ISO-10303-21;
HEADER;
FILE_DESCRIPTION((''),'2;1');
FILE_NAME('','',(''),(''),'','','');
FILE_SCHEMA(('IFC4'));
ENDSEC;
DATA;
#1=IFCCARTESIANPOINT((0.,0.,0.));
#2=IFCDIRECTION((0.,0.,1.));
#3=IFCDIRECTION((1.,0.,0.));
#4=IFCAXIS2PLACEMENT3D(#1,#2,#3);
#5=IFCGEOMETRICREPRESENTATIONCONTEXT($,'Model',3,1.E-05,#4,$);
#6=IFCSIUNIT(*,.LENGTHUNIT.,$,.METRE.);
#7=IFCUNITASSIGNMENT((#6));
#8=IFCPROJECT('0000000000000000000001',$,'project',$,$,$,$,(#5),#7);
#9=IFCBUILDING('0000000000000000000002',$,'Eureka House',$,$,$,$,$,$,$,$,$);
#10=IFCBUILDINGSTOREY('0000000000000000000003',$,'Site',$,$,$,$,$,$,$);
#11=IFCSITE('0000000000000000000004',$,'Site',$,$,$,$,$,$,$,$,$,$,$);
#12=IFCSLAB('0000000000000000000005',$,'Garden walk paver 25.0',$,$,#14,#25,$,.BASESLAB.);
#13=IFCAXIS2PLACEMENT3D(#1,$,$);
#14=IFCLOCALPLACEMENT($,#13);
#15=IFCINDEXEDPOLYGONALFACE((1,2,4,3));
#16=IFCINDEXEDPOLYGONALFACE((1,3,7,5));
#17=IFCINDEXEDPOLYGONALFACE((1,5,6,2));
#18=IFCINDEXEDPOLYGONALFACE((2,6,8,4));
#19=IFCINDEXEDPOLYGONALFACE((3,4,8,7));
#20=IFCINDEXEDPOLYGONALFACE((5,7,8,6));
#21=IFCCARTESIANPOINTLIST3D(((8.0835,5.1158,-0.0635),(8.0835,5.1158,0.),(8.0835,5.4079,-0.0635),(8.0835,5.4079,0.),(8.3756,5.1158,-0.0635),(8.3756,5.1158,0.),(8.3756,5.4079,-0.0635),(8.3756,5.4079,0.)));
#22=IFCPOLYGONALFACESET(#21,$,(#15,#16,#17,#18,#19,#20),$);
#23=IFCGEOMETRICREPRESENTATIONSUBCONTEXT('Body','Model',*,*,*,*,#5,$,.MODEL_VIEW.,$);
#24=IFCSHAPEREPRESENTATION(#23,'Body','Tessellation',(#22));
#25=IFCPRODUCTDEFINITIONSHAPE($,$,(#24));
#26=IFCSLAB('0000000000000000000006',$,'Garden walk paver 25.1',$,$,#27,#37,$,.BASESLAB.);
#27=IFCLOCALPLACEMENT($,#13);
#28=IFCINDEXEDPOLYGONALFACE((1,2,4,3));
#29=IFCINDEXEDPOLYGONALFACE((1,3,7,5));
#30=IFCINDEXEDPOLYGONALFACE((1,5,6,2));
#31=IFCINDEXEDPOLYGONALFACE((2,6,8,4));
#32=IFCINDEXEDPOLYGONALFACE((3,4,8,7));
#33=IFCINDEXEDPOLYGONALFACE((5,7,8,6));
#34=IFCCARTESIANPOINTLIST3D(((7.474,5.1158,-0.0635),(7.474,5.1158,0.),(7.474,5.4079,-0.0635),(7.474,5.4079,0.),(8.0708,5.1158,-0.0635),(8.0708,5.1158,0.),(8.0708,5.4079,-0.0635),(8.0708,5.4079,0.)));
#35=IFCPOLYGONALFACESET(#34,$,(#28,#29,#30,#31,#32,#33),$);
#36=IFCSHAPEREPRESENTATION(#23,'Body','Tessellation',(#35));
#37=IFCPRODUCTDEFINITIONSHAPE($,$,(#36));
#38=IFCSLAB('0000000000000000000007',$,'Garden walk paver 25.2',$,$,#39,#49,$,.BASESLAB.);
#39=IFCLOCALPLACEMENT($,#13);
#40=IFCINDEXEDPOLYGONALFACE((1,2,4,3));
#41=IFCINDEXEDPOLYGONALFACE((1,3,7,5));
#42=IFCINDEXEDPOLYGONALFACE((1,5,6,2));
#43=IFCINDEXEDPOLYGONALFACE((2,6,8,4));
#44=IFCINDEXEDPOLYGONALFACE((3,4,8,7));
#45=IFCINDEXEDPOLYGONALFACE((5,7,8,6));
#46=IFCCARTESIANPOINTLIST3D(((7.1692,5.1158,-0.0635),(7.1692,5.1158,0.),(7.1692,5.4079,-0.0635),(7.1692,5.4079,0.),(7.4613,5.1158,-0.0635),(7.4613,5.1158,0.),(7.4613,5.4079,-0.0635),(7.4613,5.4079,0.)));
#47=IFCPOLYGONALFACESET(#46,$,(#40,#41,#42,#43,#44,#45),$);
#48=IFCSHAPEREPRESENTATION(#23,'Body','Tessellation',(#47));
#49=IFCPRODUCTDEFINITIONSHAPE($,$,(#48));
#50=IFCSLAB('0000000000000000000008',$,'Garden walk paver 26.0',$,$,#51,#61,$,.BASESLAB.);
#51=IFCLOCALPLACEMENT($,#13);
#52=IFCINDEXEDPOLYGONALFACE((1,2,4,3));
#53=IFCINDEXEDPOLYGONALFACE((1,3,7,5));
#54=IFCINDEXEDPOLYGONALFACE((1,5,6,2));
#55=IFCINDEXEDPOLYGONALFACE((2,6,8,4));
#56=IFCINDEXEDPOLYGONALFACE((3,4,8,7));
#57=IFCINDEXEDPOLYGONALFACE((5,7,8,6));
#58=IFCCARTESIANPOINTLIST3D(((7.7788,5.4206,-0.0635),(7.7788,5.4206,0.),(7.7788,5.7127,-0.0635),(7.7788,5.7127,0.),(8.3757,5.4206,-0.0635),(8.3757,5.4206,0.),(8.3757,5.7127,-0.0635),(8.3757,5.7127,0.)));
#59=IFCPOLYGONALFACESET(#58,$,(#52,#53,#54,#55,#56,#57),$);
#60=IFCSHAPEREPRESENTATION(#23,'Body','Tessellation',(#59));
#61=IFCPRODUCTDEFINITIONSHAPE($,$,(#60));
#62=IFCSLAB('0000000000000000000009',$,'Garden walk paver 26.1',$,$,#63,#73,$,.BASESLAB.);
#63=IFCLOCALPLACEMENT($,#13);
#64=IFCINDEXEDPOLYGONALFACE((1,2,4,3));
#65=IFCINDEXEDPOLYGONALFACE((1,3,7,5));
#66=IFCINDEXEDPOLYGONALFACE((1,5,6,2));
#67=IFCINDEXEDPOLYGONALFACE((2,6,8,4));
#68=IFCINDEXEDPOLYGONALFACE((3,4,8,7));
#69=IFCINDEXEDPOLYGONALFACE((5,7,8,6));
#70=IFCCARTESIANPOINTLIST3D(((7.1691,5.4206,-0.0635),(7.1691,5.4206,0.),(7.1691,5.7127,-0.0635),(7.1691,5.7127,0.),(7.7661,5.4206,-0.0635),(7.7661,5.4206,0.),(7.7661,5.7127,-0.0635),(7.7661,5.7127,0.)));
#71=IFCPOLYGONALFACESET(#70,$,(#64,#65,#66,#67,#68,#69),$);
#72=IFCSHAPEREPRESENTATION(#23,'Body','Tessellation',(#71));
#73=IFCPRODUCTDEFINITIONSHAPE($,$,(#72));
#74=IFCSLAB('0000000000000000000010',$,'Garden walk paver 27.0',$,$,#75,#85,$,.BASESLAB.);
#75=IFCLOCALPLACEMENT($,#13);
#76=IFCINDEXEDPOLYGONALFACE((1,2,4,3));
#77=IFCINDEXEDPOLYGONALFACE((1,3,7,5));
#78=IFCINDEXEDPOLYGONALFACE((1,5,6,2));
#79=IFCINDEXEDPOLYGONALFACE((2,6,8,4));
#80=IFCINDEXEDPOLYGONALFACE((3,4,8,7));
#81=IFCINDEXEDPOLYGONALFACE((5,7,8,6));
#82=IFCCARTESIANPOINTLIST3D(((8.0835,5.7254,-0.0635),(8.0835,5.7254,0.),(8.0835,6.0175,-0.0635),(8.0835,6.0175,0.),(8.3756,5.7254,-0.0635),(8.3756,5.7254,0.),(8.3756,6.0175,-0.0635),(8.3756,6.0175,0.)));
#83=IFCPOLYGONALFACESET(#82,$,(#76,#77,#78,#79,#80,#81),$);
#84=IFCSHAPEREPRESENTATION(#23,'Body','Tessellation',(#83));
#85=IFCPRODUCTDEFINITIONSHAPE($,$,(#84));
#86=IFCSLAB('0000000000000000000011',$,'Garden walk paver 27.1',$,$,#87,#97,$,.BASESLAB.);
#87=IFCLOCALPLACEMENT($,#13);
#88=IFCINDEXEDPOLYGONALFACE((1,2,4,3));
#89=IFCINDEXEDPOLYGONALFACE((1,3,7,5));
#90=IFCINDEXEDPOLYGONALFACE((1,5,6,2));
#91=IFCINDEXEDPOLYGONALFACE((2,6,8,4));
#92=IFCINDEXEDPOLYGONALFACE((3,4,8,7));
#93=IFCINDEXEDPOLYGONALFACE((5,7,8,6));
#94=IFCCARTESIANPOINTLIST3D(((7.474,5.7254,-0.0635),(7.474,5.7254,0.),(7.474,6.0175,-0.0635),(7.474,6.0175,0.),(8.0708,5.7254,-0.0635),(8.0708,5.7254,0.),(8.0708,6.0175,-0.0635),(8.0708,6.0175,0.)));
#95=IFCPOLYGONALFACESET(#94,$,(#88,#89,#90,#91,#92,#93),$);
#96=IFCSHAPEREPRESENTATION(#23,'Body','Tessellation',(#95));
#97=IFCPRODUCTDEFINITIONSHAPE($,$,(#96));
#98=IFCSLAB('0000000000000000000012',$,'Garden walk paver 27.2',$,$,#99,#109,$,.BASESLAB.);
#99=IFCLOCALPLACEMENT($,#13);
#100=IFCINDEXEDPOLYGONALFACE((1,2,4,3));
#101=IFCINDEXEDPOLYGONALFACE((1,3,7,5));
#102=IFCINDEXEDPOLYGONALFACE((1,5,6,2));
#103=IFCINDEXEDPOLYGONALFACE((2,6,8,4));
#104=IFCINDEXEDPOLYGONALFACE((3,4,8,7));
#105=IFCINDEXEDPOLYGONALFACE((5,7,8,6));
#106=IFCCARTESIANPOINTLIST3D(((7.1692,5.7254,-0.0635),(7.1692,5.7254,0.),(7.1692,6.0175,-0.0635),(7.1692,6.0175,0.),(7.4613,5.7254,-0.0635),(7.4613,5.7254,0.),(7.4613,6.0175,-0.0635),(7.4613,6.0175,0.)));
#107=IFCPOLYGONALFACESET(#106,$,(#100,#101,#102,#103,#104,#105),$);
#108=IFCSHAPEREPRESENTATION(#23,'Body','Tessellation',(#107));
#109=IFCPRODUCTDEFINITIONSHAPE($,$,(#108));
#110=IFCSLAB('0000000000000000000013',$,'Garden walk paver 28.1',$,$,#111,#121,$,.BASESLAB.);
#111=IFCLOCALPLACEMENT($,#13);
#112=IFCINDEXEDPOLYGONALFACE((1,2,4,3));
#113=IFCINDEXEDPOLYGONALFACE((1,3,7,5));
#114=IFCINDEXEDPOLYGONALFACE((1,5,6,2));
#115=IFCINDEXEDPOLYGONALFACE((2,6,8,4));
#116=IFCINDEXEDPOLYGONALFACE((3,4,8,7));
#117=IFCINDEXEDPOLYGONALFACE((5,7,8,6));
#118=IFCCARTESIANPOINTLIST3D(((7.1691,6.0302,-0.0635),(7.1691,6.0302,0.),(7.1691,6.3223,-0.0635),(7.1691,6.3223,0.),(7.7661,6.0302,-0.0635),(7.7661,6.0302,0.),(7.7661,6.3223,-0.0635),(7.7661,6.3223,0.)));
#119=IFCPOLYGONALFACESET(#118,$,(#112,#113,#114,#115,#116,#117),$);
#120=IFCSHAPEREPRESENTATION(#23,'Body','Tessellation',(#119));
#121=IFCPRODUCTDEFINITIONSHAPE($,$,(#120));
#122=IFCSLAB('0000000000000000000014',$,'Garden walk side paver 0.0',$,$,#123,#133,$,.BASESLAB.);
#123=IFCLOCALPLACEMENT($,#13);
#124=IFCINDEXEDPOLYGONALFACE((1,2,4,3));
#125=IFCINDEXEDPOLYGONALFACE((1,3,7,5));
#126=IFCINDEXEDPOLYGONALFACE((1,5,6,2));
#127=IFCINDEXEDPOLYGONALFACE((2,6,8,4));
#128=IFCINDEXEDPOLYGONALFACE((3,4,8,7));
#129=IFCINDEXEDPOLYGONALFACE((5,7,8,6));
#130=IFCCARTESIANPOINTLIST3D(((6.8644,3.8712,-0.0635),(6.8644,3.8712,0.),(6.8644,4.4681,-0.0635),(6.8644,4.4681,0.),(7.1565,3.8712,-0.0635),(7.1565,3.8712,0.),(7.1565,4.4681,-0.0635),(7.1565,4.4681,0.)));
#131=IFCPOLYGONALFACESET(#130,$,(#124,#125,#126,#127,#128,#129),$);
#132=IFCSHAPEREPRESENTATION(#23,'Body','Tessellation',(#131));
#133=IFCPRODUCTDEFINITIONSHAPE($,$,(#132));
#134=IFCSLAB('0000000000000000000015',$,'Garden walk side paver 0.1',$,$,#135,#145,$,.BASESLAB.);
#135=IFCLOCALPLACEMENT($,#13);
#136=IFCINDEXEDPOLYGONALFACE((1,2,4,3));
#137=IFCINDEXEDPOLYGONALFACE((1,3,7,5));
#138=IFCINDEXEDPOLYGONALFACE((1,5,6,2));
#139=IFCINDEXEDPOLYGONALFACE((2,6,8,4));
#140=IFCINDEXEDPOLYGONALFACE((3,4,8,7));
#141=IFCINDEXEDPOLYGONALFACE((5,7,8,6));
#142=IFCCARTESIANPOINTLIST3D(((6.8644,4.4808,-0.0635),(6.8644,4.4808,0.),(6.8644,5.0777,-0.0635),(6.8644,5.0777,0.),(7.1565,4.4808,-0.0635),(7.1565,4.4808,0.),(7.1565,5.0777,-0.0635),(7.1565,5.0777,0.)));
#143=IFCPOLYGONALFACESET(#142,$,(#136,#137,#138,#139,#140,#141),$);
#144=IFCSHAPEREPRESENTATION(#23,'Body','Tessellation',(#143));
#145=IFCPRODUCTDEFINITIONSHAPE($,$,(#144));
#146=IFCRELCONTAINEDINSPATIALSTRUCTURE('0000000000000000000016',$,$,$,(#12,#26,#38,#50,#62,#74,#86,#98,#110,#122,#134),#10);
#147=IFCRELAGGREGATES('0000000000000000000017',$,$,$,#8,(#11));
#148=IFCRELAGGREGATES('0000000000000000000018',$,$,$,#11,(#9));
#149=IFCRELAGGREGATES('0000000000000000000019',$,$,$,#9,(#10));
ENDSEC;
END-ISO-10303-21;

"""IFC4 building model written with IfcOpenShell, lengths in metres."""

from ifc_helpers import new_model, si_unit, frame, origin, origin_with_axes, origin_2d, place, context, subcontext, project, spatial, rectangle, extrude, element, save


model = new_model("IFC4")

# Units and contexts
model_context = context("Model", 3, precision=1e-05, world=origin_with_axes())
body_context = subcontext(model_context, "Body", "Model", "MODEL_VIEW")
ifc_project = project(units=[si_unit("LENGTHUNIT", "METRE")], contexts=[model_context])

# Site, building, storey
site = spatial("IfcSite", under=ifc_project, Name="Site")
building = spatial("IfcBuilding", under=site, Name="Eureka House")
storey = spatial("IfcBuildingStorey", under=building, Name="Site")

# Slabs
slab_1_placement = place(None, frame((8.2296, 5.2619, -0.0635), z_axis=(0.0, 0.0, 1.0), x_axis=(1.0, 0.0, 0.0)))
element("IfcSlab", 1, at=slab_1_placement, inside=storey, Name="Garden walk paver 25.0", PredefinedType="BASESLAB", context=body_context, shape_type="SweptSolid", body=[
    extrude(rectangle(XDim=0.2921, YDim=0.2921, at=origin_2d()), origin(), (0.0, 0.0, 1.0), 0.0635),
])
slab_2_placement = place(None, frame((7.7724, 5.2619, -0.0635), z_axis=(0.0, 0.0, 1.0), x_axis=(1.0, 0.0, 0.0)))
element("IfcSlab", 2, at=slab_2_placement, inside=storey, Name="Garden walk paver 25.1", PredefinedType="BASESLAB", context=body_context, shape_type="SweptSolid", body=[
    extrude(rectangle(XDim=0.5969, YDim=0.2921, at=origin_2d()), origin(), (0.0, 0.0, 1.0), 0.0635),
])
slab_3_placement = place(None, frame((7.3152, 5.2619, -0.0635), z_axis=(0.0, 0.0, 1.0), x_axis=(1.0, 0.0, 0.0)))
element("IfcSlab", 3, at=slab_3_placement, inside=storey, Name="Garden walk paver 25.2", PredefinedType="BASESLAB", context=body_context, shape_type="SweptSolid", body=[
    extrude(rectangle(XDim=0.2921, YDim=0.2921, at=origin_2d()), origin(), (0.0, 0.0, 1.0), 0.0635),
])
for number, where, z_axis, x_axis, name in (
    (4, (8.0772, 5.5667, -0.0635), (0.0, 0.0, 1.0), (1.0, 0.0, 0.0), "Garden walk paver 26.0"),
    (5, (7.4676, 5.5667, -0.0635), (0.0, 0.0, 1.0), (1.0, 0.0, 0.0), "Garden walk paver 26.1"),
):
    element("IfcSlab", number, at=place(None, frame(where, z_axis=z_axis, x_axis=x_axis)), inside=storey, Name=name, PredefinedType="BASESLAB", context=body_context, shape_type="SweptSolid", body=[
        extrude(rectangle(XDim=0.5969, YDim=0.2921, at=origin_2d()), origin(), (0.0, 0.0, 1.0), 0.0635),
    ])
slab_4_placement = place(None, frame((8.2296, 5.8715, -0.0635), z_axis=(0.0, 0.0, 1.0), x_axis=(1.0, 0.0, 0.0)))
element("IfcSlab", 6, at=slab_4_placement, inside=storey, Name="Garden walk paver 27.0", PredefinedType="BASESLAB", context=body_context, shape_type="SweptSolid", body=[
    extrude(rectangle(XDim=0.2921, YDim=0.2921, at=origin_2d()), origin(), (0.0, 0.0, 1.0), 0.0635),
])
slab_5_placement = place(None, frame((7.7724, 5.8715, -0.0635), z_axis=(0.0, 0.0, 1.0), x_axis=(1.0, 0.0, 0.0)))
element("IfcSlab", 7, at=slab_5_placement, inside=storey, Name="Garden walk paver 27.1", PredefinedType="BASESLAB", context=body_context, shape_type="SweptSolid", body=[
    extrude(rectangle(XDim=0.5969, YDim=0.2921, at=origin_2d()), origin(), (0.0, 0.0, 1.0), 0.0635),
])
slab_6_placement = place(None, frame((7.3152, 5.8715, -0.0635), z_axis=(0.0, 0.0, 1.0), x_axis=(1.0, 0.0, 0.0)))
element("IfcSlab", 8, at=slab_6_placement, inside=storey, Name="Garden walk paver 27.2", PredefinedType="BASESLAB", context=body_context, shape_type="SweptSolid", body=[
    extrude(rectangle(XDim=0.2921, YDim=0.2921, at=origin_2d()), origin(), (0.0, 0.0, 1.0), 0.0635),
])
slab_7_placement = place(None, frame((7.4676, 6.1763, -0.0635), z_axis=(0.0, 0.0, 1.0), x_axis=(1.0, 0.0, 0.0)))
element("IfcSlab", 9, at=slab_7_placement, inside=storey, Name="Garden walk paver 28.1", PredefinedType="BASESLAB", context=body_context, shape_type="SweptSolid", body=[
    extrude(rectangle(XDim=0.5969, YDim=0.2921, at=origin_2d()), origin(), (0.0, 0.0, 1.0), 0.0635),
])
slab_8_placement = place(None, frame((7.0104, 4.1697, -0.0635), z_axis=(0.0, 0.0, 1.0), x_axis=(1.0, 0.0, 0.0)))
element("IfcSlab", 10, at=slab_8_placement, inside=storey, Name="Garden walk side paver 0.0", PredefinedType="BASESLAB", context=body_context, shape_type="SweptSolid", body=[
    extrude(rectangle(XDim=0.2921, YDim=0.5969, at=origin_2d()), origin(), (0.0, 0.0, 1.0), 0.0635),
])
slab_9_placement = place(None, frame((7.0104, 4.7793, -0.0635), z_axis=(0.0, 0.0, 1.0), x_axis=(1.0, 0.0, 0.0)))
element("IfcSlab", 11, at=slab_9_placement, inside=storey, Name="Garden walk side paver 0.1", PredefinedType="BASESLAB", context=body_context, shape_type="SweptSolid", body=[
    extrude(rectangle(XDim=0.2921, YDim=0.5969, at=origin_2d()), origin(), (0.0, 0.0, 1.0), 0.0635),
])

save(model, "model.ifc")
